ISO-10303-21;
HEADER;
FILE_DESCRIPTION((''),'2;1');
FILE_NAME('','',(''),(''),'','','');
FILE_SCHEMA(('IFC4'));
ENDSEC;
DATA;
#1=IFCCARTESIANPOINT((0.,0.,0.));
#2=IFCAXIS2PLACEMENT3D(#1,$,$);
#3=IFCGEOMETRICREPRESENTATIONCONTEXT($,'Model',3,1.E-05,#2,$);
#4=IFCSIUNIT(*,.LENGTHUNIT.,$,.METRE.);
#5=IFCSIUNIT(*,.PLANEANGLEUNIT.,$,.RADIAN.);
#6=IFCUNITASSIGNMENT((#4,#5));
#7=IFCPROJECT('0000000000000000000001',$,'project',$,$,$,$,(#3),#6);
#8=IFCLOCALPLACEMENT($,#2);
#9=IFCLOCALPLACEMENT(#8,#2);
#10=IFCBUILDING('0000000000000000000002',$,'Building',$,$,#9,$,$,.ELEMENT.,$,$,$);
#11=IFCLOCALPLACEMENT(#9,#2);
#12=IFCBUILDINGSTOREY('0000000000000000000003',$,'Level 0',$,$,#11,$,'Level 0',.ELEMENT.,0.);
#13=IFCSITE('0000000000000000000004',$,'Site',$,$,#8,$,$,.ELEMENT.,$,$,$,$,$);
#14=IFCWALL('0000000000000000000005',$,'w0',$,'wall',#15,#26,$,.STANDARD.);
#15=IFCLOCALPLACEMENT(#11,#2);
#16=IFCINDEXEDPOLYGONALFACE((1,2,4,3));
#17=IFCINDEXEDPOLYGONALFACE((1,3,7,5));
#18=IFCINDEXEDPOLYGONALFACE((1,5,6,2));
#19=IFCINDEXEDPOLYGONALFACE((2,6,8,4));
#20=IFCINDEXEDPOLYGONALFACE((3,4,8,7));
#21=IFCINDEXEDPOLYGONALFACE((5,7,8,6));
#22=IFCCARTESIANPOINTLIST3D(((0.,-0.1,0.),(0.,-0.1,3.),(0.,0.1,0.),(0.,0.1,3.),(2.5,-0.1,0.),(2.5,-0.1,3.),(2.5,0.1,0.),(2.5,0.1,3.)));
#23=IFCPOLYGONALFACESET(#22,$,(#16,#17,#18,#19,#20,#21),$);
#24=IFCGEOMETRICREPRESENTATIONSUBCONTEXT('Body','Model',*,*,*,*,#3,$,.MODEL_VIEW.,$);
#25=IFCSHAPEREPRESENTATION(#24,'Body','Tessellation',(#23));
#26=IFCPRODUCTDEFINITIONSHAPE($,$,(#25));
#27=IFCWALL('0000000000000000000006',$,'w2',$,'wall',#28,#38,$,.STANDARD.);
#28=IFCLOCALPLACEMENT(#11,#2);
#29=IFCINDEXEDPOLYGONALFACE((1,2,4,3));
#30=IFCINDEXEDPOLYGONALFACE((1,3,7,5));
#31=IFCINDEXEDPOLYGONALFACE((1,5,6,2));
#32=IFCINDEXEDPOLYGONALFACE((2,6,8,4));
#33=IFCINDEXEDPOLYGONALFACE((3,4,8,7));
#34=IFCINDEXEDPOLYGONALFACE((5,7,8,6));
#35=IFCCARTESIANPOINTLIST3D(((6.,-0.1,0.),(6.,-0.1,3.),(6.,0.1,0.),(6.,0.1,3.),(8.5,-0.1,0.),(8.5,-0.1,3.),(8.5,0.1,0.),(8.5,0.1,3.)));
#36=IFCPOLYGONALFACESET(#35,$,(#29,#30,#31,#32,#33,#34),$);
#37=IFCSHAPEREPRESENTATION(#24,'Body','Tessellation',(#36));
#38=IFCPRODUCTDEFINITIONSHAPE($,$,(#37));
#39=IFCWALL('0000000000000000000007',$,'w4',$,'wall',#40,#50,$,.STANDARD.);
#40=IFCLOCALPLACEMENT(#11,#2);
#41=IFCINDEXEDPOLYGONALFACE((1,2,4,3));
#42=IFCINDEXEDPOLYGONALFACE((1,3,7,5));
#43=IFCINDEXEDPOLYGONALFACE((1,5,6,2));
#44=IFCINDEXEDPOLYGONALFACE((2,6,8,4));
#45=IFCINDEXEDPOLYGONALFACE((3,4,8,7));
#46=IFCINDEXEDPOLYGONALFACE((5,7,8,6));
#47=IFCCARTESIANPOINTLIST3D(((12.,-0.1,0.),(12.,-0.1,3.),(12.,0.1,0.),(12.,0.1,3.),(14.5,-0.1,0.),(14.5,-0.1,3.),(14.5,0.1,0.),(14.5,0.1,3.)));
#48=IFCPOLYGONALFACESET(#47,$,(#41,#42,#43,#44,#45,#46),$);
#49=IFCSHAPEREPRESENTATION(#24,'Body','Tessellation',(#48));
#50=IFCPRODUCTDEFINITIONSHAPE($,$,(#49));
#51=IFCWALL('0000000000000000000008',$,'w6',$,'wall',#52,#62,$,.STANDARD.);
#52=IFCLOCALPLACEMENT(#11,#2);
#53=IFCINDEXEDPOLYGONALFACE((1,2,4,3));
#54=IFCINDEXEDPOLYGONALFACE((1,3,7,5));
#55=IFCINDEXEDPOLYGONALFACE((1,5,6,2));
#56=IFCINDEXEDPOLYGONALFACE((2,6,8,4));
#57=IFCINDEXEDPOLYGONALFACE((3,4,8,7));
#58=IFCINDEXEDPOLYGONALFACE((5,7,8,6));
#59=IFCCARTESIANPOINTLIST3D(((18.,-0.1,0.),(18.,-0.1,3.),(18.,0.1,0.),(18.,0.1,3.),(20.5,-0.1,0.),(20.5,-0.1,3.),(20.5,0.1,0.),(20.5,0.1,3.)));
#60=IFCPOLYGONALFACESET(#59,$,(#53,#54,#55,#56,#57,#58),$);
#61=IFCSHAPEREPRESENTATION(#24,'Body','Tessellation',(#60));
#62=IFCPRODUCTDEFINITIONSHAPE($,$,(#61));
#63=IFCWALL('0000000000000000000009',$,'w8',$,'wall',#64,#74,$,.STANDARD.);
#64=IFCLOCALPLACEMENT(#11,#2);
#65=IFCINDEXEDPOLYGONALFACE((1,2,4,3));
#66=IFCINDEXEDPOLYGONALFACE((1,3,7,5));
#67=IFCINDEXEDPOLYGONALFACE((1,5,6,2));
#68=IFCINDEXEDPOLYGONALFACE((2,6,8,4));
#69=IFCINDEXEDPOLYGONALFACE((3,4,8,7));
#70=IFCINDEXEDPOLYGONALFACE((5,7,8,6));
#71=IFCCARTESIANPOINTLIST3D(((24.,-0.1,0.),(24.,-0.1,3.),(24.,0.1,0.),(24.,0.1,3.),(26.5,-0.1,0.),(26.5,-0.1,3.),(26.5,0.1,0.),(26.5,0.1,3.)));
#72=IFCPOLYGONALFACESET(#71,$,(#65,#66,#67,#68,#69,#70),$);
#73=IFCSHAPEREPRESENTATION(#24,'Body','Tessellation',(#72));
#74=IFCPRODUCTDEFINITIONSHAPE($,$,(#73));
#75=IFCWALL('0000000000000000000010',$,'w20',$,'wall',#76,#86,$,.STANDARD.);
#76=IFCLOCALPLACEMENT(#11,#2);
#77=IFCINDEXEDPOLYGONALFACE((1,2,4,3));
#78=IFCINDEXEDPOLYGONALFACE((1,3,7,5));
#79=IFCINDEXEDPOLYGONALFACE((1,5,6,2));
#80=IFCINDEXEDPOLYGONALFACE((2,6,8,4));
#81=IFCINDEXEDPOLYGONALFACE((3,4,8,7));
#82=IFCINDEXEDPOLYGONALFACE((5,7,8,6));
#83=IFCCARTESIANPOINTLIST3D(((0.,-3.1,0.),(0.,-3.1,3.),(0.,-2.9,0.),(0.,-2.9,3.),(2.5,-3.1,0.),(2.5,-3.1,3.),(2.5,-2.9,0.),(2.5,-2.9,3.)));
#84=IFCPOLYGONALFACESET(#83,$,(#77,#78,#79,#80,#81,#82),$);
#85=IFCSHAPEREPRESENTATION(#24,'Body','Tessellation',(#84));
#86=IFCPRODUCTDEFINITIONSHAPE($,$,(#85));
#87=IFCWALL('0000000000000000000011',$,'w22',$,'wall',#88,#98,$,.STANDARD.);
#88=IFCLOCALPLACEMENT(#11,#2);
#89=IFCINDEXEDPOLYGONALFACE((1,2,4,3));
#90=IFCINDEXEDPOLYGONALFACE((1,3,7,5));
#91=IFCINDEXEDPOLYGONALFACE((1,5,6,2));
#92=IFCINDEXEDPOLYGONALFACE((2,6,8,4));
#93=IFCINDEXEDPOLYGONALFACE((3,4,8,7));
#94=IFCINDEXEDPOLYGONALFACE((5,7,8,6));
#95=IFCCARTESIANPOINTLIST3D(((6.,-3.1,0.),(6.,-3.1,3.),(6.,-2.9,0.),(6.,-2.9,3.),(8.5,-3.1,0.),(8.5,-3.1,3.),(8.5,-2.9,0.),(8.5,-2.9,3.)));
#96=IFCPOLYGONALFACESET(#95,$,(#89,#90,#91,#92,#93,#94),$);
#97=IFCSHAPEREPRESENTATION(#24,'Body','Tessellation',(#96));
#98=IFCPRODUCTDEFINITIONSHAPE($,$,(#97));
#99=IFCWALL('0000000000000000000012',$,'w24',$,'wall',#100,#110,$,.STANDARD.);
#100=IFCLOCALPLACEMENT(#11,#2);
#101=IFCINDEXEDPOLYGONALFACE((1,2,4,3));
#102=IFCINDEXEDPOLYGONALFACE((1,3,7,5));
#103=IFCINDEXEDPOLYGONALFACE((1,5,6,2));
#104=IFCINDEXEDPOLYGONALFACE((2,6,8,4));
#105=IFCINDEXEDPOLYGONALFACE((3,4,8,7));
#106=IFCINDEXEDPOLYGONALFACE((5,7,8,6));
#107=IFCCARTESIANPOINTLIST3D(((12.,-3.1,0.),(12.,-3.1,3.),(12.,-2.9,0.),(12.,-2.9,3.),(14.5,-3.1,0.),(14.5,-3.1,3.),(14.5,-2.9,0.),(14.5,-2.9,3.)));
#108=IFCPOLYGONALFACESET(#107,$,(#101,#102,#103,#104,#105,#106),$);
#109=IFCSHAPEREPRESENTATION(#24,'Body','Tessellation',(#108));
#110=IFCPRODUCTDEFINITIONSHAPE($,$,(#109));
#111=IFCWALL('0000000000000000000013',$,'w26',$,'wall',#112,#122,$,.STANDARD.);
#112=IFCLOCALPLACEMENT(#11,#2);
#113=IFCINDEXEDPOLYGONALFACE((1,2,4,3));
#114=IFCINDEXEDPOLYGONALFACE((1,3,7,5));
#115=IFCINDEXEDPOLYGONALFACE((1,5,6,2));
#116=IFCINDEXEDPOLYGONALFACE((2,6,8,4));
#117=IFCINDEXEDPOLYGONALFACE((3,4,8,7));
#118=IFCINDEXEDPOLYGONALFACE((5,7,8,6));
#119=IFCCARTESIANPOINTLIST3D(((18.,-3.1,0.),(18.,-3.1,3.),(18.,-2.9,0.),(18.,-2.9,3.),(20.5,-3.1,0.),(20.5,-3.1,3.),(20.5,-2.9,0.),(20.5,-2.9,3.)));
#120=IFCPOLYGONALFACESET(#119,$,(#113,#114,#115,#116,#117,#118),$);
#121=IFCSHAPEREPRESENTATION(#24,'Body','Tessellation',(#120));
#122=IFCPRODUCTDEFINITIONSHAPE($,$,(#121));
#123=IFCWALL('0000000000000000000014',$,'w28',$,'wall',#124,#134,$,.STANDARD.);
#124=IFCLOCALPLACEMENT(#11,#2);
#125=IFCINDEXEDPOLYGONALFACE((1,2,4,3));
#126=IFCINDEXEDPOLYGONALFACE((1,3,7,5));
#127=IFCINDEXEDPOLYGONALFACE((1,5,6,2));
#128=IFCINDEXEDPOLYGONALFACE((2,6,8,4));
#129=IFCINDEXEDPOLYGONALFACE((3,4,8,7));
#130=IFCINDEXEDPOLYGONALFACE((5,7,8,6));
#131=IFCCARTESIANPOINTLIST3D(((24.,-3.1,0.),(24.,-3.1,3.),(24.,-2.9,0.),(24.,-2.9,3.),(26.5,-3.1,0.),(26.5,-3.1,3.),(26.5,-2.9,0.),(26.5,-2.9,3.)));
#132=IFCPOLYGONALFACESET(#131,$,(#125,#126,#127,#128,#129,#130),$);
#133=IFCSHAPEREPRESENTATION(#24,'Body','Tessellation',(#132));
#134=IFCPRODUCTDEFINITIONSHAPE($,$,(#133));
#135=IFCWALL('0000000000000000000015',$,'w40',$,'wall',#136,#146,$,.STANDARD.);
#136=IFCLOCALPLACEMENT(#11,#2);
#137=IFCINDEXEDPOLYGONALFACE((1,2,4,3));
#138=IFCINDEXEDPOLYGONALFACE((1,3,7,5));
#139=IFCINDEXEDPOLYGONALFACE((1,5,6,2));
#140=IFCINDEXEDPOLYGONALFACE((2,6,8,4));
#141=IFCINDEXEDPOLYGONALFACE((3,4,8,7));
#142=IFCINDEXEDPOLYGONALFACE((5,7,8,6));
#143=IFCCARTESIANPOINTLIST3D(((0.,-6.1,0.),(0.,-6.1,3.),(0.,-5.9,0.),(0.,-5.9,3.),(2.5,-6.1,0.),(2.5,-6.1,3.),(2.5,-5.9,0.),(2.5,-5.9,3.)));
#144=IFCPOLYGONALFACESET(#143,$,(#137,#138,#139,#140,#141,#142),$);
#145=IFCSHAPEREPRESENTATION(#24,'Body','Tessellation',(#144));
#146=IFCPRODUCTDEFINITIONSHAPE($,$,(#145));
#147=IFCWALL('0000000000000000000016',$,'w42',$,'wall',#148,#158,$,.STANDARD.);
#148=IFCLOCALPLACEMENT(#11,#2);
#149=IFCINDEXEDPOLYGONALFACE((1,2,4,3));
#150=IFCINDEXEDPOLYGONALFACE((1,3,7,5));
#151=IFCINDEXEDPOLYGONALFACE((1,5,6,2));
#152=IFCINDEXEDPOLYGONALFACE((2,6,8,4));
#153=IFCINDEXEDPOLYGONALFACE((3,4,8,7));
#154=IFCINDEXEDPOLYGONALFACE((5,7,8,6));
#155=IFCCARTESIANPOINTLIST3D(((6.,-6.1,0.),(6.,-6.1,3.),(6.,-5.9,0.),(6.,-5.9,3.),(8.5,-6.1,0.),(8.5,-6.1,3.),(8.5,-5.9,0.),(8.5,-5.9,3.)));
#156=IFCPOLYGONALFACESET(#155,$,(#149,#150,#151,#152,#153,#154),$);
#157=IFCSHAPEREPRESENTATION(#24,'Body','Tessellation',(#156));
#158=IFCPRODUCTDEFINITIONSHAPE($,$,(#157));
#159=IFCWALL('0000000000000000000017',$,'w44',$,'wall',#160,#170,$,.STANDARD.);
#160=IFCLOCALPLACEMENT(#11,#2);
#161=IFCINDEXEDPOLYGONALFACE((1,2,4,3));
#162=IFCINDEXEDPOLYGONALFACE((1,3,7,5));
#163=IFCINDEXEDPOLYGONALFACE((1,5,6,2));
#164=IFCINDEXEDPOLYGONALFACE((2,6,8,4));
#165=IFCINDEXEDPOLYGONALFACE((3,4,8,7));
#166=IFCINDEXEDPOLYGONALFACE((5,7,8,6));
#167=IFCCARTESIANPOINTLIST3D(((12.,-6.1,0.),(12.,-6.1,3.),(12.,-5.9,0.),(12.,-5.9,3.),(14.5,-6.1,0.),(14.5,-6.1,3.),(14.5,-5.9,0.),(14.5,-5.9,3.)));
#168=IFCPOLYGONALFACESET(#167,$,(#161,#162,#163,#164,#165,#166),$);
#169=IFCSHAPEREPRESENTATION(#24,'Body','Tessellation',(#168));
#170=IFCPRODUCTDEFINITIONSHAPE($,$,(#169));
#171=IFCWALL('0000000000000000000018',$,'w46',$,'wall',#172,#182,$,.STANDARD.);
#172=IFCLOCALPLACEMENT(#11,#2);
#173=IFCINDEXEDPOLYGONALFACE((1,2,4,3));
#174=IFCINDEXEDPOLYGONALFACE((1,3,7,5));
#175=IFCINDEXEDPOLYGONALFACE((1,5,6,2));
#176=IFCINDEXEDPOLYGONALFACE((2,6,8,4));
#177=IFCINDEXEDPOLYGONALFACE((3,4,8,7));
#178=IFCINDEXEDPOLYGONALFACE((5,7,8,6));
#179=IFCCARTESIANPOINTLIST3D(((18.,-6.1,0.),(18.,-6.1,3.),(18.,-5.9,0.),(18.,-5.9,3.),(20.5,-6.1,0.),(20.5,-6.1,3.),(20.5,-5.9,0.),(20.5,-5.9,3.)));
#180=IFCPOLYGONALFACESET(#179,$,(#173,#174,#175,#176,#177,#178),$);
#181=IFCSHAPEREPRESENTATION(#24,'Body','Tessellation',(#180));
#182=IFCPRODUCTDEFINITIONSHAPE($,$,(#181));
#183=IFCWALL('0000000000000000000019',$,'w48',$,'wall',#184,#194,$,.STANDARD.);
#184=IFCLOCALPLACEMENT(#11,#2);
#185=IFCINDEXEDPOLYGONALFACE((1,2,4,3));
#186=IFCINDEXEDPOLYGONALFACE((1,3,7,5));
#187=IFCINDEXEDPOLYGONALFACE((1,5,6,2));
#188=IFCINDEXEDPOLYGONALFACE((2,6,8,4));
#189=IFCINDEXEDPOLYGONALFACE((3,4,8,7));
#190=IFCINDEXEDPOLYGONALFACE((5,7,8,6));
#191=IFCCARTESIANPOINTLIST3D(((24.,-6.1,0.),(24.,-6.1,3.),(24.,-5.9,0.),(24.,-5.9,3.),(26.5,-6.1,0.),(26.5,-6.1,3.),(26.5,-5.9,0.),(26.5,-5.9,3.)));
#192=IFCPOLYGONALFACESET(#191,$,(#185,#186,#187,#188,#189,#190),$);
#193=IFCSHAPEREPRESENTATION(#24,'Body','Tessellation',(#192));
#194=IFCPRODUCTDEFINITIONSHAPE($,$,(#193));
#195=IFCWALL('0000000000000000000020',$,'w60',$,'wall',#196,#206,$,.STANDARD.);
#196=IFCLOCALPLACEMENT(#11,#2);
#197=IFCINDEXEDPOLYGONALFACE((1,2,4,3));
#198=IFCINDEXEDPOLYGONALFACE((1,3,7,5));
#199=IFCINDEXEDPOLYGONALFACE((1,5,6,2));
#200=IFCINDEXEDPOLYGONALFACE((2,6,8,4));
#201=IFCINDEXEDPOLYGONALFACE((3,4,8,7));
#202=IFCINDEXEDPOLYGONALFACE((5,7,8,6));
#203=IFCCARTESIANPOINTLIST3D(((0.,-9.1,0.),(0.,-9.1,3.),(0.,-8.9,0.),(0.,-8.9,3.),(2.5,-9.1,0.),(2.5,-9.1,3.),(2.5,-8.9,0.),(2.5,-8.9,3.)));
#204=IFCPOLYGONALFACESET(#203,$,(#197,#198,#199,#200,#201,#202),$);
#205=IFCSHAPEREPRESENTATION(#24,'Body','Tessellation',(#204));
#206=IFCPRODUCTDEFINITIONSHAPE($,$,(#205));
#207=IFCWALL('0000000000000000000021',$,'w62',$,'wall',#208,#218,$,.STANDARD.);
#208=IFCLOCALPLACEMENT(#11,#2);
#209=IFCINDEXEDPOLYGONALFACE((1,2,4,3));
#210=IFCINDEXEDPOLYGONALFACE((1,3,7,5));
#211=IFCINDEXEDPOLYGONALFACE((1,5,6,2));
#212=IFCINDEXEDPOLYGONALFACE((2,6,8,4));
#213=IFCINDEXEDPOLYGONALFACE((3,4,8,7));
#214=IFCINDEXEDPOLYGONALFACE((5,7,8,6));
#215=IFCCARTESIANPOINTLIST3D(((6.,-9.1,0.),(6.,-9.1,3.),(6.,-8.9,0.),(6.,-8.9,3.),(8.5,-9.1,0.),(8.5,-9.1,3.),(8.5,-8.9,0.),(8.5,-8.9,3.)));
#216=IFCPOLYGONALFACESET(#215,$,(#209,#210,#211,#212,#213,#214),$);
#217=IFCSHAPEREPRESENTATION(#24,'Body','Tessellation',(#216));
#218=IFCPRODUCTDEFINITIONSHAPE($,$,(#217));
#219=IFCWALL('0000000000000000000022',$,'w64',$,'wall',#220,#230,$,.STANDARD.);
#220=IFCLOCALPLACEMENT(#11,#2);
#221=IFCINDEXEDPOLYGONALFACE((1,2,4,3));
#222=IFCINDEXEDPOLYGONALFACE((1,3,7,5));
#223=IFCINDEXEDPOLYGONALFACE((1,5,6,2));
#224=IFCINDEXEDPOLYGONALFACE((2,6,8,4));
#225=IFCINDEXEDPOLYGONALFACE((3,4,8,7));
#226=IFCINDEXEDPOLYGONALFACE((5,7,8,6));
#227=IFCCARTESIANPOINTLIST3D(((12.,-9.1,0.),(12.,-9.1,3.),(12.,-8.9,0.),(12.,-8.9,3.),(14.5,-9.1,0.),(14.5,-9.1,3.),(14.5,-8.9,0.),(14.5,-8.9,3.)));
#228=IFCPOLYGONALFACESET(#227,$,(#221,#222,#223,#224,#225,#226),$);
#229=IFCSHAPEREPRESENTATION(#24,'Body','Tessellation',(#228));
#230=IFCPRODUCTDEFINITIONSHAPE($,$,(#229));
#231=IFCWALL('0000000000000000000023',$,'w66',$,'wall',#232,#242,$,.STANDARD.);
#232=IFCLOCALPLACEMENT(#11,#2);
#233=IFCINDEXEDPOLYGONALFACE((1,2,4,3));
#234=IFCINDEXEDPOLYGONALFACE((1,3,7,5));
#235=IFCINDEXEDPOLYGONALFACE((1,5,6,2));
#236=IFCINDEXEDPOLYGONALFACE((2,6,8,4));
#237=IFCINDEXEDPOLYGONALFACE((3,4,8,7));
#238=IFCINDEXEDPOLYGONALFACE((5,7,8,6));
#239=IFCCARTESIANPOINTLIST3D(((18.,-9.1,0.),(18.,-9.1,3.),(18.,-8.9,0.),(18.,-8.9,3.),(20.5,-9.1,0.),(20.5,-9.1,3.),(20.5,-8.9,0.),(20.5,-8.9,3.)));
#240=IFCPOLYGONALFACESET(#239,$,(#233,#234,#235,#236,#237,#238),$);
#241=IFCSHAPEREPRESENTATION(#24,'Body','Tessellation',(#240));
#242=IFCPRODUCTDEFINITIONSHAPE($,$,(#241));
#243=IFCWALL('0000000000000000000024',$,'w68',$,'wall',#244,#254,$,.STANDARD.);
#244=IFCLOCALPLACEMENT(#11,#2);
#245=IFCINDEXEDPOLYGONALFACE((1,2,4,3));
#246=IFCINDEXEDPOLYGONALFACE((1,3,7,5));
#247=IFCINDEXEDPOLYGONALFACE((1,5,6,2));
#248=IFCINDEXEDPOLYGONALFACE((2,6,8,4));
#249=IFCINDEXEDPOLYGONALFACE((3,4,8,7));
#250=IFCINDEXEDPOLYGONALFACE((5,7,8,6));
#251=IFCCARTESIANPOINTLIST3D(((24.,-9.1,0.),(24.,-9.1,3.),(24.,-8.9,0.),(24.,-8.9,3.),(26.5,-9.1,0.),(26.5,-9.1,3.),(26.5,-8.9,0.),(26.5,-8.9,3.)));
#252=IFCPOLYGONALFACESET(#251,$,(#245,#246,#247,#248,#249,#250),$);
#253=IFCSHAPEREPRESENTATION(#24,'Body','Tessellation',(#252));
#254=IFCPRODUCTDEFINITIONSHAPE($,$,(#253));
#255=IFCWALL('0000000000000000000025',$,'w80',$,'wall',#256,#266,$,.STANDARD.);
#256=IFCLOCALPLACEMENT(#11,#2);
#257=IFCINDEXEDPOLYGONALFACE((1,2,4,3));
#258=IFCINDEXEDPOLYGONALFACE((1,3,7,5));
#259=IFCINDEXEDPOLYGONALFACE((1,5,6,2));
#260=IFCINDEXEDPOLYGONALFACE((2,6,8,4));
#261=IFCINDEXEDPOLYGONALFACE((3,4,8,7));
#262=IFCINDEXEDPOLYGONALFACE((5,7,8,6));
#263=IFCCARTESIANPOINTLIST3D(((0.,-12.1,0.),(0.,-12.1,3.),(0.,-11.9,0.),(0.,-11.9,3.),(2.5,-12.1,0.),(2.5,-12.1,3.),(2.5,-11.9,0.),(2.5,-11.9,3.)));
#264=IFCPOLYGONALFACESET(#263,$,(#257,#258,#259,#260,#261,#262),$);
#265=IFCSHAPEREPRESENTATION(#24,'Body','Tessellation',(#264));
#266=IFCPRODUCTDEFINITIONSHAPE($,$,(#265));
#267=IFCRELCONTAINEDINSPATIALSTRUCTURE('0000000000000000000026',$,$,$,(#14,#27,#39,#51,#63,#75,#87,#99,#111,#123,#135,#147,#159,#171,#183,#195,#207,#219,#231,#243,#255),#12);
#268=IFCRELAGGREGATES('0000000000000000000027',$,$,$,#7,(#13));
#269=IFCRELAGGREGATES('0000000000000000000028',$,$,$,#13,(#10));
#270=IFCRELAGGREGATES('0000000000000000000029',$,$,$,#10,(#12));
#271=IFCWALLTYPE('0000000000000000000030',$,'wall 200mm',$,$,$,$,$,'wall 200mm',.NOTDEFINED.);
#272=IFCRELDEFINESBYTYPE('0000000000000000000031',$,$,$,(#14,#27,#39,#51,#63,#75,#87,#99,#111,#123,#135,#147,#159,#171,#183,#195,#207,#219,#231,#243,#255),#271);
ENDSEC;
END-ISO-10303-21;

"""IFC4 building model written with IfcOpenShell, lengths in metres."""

from ifc_helpers import new_model, si_unit, frame, frame_2d, origin, place, context, subcontext, project, spatial, rectangle, extrude, type_object, element, save


model = new_model("IFC4")

# Units and contexts
model_context = context("Model", 3, precision=1e-05, world=origin())
body_context = subcontext(model_context, "Body", "Model", "MODEL_VIEW")
ifc_project = project(units=[si_unit("LENGTHUNIT", "METRE"), si_unit("PLANEANGLEUNIT", "RADIAN")], contexts=[model_context])

# Site, building, storey
site_placement = place(None, origin())
site = spatial("IfcSite", under=ifc_project, at=site_placement, Name="Site", CompositionType="ELEMENT")
building_placement = place(site_placement, origin())
building = spatial("IfcBuilding", under=site, at=building_placement, Name="Building", CompositionType="ELEMENT")
storey_placement = place(building_placement, origin())
storey = spatial("IfcBuildingStorey", under=building, at=storey_placement, Name="Level 0", LongName="Level 0", CompositionType="ELEMENT", Elevation=0.0)

# Walls
wall_type = type_object("IfcWallType", Name="wall 200mm", ElementType="wall 200mm", PredefinedType="NOTDEFINED")
for number, where, z_axis, x_axis, name in (
    (1, (0.0, 0.0, 0.0), (0.0, 0.0, 1.0), (1.0, 0.0, 0.0), "w0"),
    (2, (6.0, 0.0, 0.0), (0.0, 0.0, 1.0), (1.0, 0.0, 0.0), "w2"),
    (3, (12.0, 0.0, 0.0), (0.0, 0.0, 1.0), (1.0, 0.0, 0.0), "w4"),
    (4, (18.0, 0.0, 0.0), (0.0, 0.0, 1.0), (1.0, 0.0, 0.0), "w6"),
    (5, (24.0, 0.0, 0.0), (0.0, 0.0, 1.0), (1.0, 0.0, 0.0), "w8"),
    (6, (0.0, -3.0, 0.0), (0.0, 0.0, 1.0), (1.0, 0.0, 0.0), "w20"),
    (7, (6.0, -3.0, 0.0), (0.0, 0.0, 1.0), (1.0, 0.0, 0.0), "w22"),
    (8, (12.0, -3.0, 0.0), (0.0, 0.0, 1.0), (1.0, 0.0, 0.0), "w24"),
    (9, (18.0, -3.0, 0.0), (0.0, 0.0, 1.0), (1.0, 0.0, 0.0), "w26"),
    (10, (24.0, -3.0, 0.0), (0.0, 0.0, 1.0), (1.0, 0.0, 0.0), "w28"),
    (11, (0.0, -6.0, 0.0), (0.0, 0.0, 1.0), (1.0, 0.0, 0.0), "w40"),
    (12, (6.0, -6.0, 0.0), (0.0, 0.0, 1.0), (1.0, 0.0, 0.0), "w42"),
    (13, (12.0, -6.0, 0.0), (0.0, 0.0, 1.0), (1.0, 0.0, 0.0), "w44"),
    (14, (18.0, -6.0, 0.0), (0.0, 0.0, 1.0), (1.0, 0.0, 0.0), "w46"),
    (15, (24.0, -6.0, 0.0), (0.0, 0.0, 1.0), (1.0, 0.0, 0.0), "w48"),
    (16, (0.0, -9.0, 0.0), (0.0, 0.0, 1.0), (1.0, 0.0, 0.0), "w60"),
    (17, (6.0, -9.0, 0.0), (0.0, 0.0, 1.0), (1.0, 0.0, 0.0), "w62"),
    (18, (12.0, -9.0, 0.0), (0.0, 0.0, 1.0), (1.0, 0.0, 0.0), "w64"),
    (19, (18.0, -9.0, 0.0), (0.0, 0.0, 1.0), (1.0, 0.0, 0.0), "w66"),
    (20, (24.0, -9.0, 0.0), (0.0, 0.0, 1.0), (1.0, 0.0, 0.0), "w68"),
    (21, (0.0, -12.0, 0.0), (0.0, 0.0, 1.0), (1.0, 0.0, 0.0), "w80"),
):
    element("IfcWall", number, at=place(storey_placement, frame(where, z_axis=z_axis, x_axis=x_axis)), inside=storey, type_object=wall_type, Name=name, ObjectType="wall", PredefinedType="STANDARD", context=body_context, shape_type="SweptSolid", body=[
        extrude(rectangle(XDim=2.5, YDim=0.2, at=frame_2d((1.25, 0.0))), origin(), (0.0, 0.0, 1.0), 3.0),
    ])

save(model, "model.ifc")
